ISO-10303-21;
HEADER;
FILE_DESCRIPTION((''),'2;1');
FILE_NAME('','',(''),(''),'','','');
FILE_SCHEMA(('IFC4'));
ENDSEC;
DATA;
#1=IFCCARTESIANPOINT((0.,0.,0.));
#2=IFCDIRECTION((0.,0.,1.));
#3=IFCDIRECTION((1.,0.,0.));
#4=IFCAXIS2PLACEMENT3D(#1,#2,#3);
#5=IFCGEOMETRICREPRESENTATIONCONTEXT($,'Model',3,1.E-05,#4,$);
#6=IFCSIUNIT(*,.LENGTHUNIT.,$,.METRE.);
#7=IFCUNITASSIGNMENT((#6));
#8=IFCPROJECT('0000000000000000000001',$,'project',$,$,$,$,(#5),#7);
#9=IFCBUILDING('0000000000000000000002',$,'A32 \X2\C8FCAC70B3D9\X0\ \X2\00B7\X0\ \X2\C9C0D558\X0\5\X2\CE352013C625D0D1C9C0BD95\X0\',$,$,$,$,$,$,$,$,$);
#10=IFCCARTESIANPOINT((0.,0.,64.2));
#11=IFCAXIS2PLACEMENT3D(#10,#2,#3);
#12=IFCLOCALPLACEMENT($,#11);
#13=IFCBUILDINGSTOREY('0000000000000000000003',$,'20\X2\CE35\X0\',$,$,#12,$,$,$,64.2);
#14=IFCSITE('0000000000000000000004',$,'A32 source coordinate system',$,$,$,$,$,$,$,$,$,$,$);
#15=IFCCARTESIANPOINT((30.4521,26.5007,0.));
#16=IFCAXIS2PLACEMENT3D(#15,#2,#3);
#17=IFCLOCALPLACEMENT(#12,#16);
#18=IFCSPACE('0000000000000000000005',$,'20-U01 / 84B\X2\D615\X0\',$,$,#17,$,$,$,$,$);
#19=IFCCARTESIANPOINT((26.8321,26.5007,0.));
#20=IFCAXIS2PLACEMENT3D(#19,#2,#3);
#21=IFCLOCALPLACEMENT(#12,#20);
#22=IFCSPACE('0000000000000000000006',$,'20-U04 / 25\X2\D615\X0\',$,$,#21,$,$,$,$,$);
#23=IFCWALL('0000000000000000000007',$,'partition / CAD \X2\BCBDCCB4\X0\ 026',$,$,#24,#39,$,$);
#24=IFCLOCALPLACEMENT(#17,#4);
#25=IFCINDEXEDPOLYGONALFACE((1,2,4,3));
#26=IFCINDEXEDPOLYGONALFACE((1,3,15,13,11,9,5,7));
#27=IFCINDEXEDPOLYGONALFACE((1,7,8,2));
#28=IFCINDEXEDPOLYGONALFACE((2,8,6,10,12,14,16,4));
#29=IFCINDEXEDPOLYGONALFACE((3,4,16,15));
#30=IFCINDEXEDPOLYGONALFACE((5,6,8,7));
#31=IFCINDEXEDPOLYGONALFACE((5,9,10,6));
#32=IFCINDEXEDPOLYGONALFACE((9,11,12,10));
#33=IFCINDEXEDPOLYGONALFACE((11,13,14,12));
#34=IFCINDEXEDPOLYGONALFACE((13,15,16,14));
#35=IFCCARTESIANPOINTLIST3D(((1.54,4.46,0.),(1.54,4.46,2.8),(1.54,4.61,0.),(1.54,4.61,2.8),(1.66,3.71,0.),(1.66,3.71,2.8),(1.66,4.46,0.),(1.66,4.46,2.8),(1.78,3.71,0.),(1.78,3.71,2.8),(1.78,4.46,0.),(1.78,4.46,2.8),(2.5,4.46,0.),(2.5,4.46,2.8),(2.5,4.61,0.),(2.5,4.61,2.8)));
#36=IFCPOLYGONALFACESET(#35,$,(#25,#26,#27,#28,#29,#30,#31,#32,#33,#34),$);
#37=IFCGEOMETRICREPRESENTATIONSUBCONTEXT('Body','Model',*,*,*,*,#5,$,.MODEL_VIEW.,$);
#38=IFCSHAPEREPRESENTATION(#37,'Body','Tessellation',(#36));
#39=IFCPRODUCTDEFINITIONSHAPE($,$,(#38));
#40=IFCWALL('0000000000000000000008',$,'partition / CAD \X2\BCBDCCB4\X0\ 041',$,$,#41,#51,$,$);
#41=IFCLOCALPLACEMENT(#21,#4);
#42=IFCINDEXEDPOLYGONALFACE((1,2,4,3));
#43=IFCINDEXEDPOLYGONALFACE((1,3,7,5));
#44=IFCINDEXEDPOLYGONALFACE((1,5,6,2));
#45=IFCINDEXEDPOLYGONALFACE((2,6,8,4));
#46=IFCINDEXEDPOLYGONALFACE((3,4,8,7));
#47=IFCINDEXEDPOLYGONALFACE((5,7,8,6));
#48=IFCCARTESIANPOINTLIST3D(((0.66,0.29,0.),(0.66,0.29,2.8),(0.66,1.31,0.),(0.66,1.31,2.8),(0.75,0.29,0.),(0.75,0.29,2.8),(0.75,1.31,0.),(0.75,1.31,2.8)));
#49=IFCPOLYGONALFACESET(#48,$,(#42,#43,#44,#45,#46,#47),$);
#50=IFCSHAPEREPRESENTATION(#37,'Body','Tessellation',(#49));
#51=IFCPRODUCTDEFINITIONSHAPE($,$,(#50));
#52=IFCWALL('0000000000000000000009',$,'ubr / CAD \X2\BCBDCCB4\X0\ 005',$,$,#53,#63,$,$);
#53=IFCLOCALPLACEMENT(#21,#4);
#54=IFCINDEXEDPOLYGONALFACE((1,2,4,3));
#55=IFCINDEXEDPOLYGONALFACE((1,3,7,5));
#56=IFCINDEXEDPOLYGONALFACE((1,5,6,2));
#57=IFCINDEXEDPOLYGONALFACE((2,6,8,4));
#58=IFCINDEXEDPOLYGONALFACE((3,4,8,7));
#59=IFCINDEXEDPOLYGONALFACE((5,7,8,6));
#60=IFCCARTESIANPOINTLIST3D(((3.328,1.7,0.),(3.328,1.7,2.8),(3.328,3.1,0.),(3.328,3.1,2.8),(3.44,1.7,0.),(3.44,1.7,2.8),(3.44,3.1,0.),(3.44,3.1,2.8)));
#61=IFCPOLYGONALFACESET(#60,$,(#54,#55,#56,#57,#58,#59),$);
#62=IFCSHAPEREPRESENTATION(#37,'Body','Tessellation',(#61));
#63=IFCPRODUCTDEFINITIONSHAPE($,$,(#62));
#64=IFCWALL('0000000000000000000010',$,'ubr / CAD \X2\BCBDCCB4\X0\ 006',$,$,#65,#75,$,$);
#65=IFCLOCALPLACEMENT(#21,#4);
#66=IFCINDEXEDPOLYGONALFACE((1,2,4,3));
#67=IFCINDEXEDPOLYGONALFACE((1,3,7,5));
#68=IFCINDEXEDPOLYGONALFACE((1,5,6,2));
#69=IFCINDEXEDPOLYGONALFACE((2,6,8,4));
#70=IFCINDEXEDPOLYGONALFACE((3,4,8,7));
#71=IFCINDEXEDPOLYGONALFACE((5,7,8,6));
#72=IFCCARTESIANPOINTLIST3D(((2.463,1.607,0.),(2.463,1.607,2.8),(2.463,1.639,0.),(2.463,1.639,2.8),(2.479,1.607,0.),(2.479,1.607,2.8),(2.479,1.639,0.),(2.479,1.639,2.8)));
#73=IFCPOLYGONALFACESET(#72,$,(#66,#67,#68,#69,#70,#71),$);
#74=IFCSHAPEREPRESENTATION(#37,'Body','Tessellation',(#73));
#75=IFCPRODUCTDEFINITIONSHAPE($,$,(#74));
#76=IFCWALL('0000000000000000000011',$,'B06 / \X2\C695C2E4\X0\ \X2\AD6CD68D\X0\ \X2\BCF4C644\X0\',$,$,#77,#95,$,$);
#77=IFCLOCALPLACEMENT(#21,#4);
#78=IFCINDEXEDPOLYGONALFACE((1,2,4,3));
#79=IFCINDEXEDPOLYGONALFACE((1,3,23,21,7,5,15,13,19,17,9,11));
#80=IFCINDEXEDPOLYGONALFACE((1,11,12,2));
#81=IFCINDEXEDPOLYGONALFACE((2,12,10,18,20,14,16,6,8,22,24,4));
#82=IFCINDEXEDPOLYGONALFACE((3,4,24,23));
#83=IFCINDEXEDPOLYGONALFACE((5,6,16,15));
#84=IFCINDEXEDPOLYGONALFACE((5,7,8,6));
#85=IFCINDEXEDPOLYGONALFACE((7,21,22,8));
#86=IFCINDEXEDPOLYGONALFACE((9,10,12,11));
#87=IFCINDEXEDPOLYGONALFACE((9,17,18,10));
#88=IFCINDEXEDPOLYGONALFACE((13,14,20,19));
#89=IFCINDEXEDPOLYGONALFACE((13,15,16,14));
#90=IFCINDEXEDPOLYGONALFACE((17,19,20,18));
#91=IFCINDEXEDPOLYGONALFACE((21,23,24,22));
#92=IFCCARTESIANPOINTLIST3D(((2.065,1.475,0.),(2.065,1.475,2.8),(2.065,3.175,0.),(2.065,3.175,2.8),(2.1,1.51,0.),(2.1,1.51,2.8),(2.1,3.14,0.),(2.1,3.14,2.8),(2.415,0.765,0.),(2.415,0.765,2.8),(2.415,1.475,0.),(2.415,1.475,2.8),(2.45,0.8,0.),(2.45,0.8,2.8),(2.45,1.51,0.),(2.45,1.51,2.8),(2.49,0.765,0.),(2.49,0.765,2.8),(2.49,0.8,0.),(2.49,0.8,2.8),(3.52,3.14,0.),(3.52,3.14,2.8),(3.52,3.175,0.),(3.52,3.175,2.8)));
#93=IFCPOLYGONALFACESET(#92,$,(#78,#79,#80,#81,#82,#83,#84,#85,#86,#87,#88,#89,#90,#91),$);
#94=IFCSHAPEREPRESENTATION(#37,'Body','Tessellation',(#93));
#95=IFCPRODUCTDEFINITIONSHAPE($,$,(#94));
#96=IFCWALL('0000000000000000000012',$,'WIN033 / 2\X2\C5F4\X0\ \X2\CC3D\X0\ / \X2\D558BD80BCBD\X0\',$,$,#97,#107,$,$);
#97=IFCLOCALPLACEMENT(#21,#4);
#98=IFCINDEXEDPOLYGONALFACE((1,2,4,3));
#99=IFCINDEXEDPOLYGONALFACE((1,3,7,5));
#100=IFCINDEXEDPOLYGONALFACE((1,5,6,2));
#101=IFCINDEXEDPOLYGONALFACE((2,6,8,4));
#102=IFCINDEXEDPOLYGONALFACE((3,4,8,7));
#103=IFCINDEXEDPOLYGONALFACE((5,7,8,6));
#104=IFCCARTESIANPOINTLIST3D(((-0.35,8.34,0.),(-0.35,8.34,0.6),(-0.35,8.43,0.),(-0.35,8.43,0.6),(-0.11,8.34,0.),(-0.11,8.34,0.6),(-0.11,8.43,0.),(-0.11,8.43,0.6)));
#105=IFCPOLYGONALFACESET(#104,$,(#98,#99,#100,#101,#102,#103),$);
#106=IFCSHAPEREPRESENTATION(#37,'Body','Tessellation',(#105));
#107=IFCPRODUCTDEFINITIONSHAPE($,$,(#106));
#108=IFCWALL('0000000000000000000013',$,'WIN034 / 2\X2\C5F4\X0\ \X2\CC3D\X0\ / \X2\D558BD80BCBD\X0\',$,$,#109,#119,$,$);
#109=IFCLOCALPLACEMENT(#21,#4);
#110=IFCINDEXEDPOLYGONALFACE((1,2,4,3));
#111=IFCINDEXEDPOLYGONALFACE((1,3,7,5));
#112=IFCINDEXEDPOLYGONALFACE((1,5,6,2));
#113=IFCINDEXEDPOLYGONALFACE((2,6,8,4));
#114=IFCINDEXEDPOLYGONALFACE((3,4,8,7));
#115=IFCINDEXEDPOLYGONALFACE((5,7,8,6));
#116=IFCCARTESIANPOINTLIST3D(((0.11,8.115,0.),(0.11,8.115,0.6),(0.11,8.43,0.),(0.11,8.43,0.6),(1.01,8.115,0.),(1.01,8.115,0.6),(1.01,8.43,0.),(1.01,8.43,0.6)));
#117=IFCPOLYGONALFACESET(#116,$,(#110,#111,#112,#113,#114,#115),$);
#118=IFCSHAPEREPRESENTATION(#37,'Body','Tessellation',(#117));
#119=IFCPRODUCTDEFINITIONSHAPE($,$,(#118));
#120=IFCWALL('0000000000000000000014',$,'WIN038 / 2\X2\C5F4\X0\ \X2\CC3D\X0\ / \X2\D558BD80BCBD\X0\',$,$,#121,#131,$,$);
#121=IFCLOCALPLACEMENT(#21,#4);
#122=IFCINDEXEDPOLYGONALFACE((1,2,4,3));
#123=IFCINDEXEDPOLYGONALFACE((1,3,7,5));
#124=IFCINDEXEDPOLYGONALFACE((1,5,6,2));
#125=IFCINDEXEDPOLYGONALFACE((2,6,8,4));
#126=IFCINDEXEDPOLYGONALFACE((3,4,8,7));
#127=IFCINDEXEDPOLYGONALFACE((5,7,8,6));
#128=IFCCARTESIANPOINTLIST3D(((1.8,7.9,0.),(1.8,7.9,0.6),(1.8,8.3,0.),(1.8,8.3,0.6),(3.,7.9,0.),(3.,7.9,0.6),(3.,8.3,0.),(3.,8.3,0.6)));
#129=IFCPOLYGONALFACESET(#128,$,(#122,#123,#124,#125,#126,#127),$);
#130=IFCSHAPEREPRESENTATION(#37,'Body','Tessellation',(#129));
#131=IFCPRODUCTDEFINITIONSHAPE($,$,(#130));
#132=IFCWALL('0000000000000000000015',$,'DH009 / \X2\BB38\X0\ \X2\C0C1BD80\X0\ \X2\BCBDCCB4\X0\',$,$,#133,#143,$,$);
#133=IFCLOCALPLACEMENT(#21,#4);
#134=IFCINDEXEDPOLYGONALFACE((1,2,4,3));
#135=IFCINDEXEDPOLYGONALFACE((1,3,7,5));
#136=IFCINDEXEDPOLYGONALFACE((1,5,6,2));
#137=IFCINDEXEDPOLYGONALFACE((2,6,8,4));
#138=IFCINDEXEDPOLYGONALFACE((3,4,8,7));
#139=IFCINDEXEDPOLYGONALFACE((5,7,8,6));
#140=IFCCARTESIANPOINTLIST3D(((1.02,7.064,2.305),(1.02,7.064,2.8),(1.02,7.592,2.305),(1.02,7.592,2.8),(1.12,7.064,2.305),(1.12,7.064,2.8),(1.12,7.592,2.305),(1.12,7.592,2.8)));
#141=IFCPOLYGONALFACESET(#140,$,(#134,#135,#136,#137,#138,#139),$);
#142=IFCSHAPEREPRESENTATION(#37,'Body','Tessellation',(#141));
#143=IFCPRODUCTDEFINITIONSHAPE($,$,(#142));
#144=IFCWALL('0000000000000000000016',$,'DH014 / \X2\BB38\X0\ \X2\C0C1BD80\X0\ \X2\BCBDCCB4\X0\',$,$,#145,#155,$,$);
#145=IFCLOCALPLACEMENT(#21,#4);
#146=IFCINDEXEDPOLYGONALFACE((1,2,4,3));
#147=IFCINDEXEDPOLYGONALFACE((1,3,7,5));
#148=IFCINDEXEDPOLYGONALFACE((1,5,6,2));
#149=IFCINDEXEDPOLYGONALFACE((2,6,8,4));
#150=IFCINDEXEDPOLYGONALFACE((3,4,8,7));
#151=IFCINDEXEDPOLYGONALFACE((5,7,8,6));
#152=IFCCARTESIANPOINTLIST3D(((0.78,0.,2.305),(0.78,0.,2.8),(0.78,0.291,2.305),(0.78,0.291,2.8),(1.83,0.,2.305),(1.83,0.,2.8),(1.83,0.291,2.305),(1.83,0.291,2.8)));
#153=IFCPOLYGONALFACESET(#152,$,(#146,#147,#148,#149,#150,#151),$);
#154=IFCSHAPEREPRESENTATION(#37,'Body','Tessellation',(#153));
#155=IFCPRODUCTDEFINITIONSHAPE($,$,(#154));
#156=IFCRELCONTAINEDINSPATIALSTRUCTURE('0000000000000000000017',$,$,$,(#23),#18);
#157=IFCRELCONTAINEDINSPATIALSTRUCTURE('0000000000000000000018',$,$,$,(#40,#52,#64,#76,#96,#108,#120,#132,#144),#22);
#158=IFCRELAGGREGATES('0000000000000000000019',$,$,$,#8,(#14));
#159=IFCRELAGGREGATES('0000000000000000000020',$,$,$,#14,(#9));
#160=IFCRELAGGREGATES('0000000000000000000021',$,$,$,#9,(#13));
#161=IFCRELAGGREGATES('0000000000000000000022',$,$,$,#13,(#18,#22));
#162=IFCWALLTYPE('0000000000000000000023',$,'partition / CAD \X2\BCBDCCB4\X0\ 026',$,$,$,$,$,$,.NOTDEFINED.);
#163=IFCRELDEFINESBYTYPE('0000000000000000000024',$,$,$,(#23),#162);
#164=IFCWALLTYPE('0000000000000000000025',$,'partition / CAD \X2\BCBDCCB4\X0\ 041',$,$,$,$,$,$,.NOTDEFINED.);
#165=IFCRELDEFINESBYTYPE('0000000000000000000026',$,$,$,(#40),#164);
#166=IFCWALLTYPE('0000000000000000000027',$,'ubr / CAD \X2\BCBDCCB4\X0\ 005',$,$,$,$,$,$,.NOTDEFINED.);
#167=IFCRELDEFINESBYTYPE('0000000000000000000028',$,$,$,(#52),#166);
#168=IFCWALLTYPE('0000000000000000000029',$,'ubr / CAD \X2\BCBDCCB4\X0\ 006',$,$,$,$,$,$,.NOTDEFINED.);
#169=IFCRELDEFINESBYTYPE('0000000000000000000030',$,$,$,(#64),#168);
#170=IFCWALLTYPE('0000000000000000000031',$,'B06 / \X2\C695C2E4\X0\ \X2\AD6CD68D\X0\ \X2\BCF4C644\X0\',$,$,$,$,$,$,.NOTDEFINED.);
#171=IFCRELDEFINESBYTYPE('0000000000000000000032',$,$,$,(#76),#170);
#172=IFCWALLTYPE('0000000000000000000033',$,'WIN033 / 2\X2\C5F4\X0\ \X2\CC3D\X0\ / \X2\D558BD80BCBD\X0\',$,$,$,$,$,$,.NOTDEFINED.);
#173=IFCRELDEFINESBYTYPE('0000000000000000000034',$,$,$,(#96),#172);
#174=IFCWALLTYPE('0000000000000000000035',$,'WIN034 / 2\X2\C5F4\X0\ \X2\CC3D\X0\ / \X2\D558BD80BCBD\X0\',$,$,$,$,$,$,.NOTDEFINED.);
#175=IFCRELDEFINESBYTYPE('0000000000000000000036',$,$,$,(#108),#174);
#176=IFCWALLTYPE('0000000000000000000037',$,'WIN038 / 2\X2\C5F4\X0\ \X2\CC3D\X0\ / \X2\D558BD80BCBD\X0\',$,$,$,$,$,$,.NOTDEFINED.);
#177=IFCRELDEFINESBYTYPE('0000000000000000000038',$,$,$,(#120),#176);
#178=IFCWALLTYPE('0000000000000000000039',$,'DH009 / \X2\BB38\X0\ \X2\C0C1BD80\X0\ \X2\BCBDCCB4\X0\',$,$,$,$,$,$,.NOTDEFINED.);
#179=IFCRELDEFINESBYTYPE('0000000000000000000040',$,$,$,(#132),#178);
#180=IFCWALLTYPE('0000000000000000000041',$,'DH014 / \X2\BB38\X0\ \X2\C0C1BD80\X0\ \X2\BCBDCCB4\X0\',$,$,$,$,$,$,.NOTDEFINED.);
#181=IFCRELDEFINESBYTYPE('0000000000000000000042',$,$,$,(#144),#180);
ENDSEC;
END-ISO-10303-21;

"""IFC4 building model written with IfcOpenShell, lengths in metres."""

from ifc_helpers import new_model, si_unit, frame, origin, origin_with_axes, place, context, subcontext, project, spatial, polyline, outline, extrude, source, transform, mapped, type_object, type_shapes, element, save


model = new_model("IFC4")

# Units and contexts
model_context = context("Model", 3, precision=1e-05, world=origin_with_axes())
body_context = subcontext(model_context, "Body", "Model", "MODEL_VIEW")
ifc_project = project(units=[si_unit("LENGTHUNIT", "METRE")], contexts=[model_context])

# Site, building, storey, space
site = spatial("IfcSite", under=ifc_project, Name="A32 source coordinate system")
building = spatial("IfcBuilding", under=site, Name="A32 주거동 · 지하5층–옥탑지붕")
storey_placement = place(None, frame((0.0, 0.0, 64.2), z_axis=(0.0, 0.0, 1.0), x_axis=(1.0, 0.0, 0.0)))
storey = spatial("IfcBuildingStorey", under=building, at=storey_placement, Name="20층", Elevation=64.2)
space_1_placement = place(storey_placement, frame((30.4521, 26.5007, 0.0), z_axis=(0.0, 0.0, 1.0), x_axis=(1.0, 0.0, 0.0)))
space_1 = spatial("IfcSpace", under=storey, at=space_1_placement, Name="20-U01 / 84B형")

# Wall
wall_type_1 = type_object("IfcWallType", Name="partition / CAD 벽체 026", PredefinedType="NOTDEFINED")
shared_shape_1 = source(origin(), body_context, "Body", "SweptSolid", [
    extrude(outline(polyline([(1.54, 4.46), (1.54, 4.61), (2.5, 4.61), (2.5, 4.46), (1.78, 4.46), (1.78, 3.71), (1.66, 3.71), (1.66, 4.46), (1.54, 4.46)])), origin(), (0.0, 0.0, 1.0), 2.8),
])
type_shapes(wall_type_1, [shared_shape_1])
wall_1_placement = place(space_1_placement, origin_with_axes())
element("IfcWall", 1, at=wall_1_placement, inside=space_1, type_object=wall_type_1, Name="partition / CAD 벽체 026", context=body_context, shape_type="MappedRepresentation", body=[
    mapped(shared_shape_1, transform((0.0, 0.0, 0.0), scale=1.0)),
])

# Shared definitions
space_2_placement = place(storey_placement, frame((26.8321, 26.5007, 0.0), z_axis=(0.0, 0.0, 1.0), x_axis=(1.0, 0.0, 0.0)))
space_2 = spatial("IfcSpace", under=storey, at=space_2_placement, Name="20-U04 / 25형")

# Walls
wall_type_2 = type_object("IfcWallType", Name="partition / CAD 벽체 041", PredefinedType="NOTDEFINED")
shared_shape_2 = source(origin(), body_context, "Body", "SweptSolid", [
    extrude(outline(polyline([(0.75, 1.31), (0.75, 0.29), (0.66, 0.29), (0.66, 1.31), (0.75, 1.31)])), origin(), (0.0, 0.0, 1.0), 2.8),
])
type_shapes(wall_type_2, [shared_shape_2])
wall_2_placement = place(space_2_placement, origin_with_axes())
element("IfcWall", 2, at=wall_2_placement, inside=space_2, type_object=wall_type_2, Name="partition / CAD 벽체 041", context=body_context, shape_type="MappedRepresentation", body=[
    mapped(shared_shape_2, transform((0.0, 0.0, 0.0), scale=1.0)),
])
wall_type_3 = type_object("IfcWallType", Name="ubr / CAD 벽체 005", PredefinedType="NOTDEFINED")
shared_shape_3 = source(origin(), body_context, "Body", "SweptSolid", [
    extrude(outline(polyline([(3.44, 3.1), (3.44, 1.7), (3.328, 1.7), (3.328, 3.1), (3.44, 3.1)])), origin(), (0.0, 0.0, 1.0), 2.8),
])
type_shapes(wall_type_3, [shared_shape_3])
wall_3_placement = place(space_2_placement, origin_with_axes())
element("IfcWall", 3, at=wall_3_placement, inside=space_2, type_object=wall_type_3, Name="ubr / CAD 벽체 005", context=body_context, shape_type="MappedRepresentation", body=[
    mapped(shared_shape_3, transform((0.0, 0.0, 0.0), scale=1.0)),
])
wall_type_4 = type_object("IfcWallType", Name="ubr / CAD 벽체 006", PredefinedType="NOTDEFINED")
shared_shape_4 = source(origin(), body_context, "Body", "SweptSolid", [
    extrude(outline(polyline([(2.463, 1.639), (2.479, 1.639), (2.479, 1.607), (2.463, 1.607), (2.463, 1.639)])), origin(), (0.0, 0.0, 1.0), 2.8),
])
type_shapes(wall_type_4, [shared_shape_4])
wall_4_placement = place(space_2_placement, origin_with_axes())
element("IfcWall", 4, at=wall_4_placement, inside=space_2, type_object=wall_type_4, Name="ubr / CAD 벽체 006", context=body_context, shape_type="MappedRepresentation", body=[
    mapped(shared_shape_4, transform((0.0, 0.0, 0.0), scale=1.0)),
])
wall_type_5 = type_object("IfcWallType", Name="B06 / 욕실 구획 보완", PredefinedType="NOTDEFINED")
shared_shape_5 = source(origin(), body_context, "Body", "SweptSolid", [
    extrude(outline(polyline([(3.52, 3.14), (2.1, 3.14), (2.1, 1.51), (2.45, 1.51), (2.45, 0.8), (2.49, 0.8), (2.49, 0.765), (2.415, 0.765), (2.415, 1.475), (2.065, 1.475), (2.065, 3.175), (3.52, 3.175), (3.52, 3.14)])), origin(), (0.0, 0.0, 1.0), 2.8),
])
type_shapes(wall_type_5, [shared_shape_5])
wall_5_placement = place(space_2_placement, origin_with_axes())
element("IfcWall", 5, at=wall_5_placement, inside=space_2, type_object=wall_type_5, Name="B06 / 욕실 구획 보완", context=body_context, shape_type="MappedRepresentation", body=[
    mapped(shared_shape_5, transform((0.0, 0.0, 0.0), scale=1.0)),
])
wall_type_6 = type_object("IfcWallType", Name="WIN033 / 2열 창 / 하부벽", PredefinedType="NOTDEFINED")
shared_shape_6 = source(origin(), body_context, "Body", "SweptSolid", [
    extrude(outline(polyline([(-0.11, 8.43), (-0.11, 8.34), (-0.35, 8.34), (-0.35, 8.43), (-0.11, 8.43)])), origin(), (0.0, 0.0, 1.0), 0.6),
])
type_shapes(wall_type_6, [shared_shape_6])
wall_6_placement = place(space_2_placement, origin_with_axes())
element("IfcWall", 6, at=wall_6_placement, inside=space_2, type_object=wall_type_6, Name="WIN033 / 2열 창 / 하부벽", context=body_context, shape_type="MappedRepresentation", body=[
    mapped(shared_shape_6, transform((0.0, 0.0, 0.0), scale=1.0)),
])
wall_type_7 = type_object("IfcWallType", Name="WIN034 / 2열 창 / 하부벽", PredefinedType="NOTDEFINED")
shared_shape_7 = source(origin(), body_context, "Body", "SweptSolid", [
    extrude(outline(polyline([(0.11, 8.115), (0.11, 8.43), (1.01, 8.43), (1.01, 8.115), (0.11, 8.115)])), origin(), (0.0, 0.0, 1.0), 0.6),
])
type_shapes(wall_type_7, [shared_shape_7])
wall_7_placement = place(space_2_placement, origin_with_axes())
element("IfcWall", 7, at=wall_7_placement, inside=space_2, type_object=wall_type_7, Name="WIN034 / 2열 창 / 하부벽", context=body_context, shape_type="MappedRepresentation", body=[
    mapped(shared_shape_7, transform((0.0, 0.0, 0.0), scale=1.0)),
])
wall_type_8 = type_object("IfcWallType", Name="WIN038 / 2열 창 / 하부벽", PredefinedType="NOTDEFINED")
shared_shape_8 = source(origin(), body_context, "Body", "SweptSolid", [
    extrude(outline(polyline([(1.8, 7.9), (1.8, 8.3), (3.0, 8.3), (3.0, 7.9), (1.8, 7.9)])), origin(), (0.0, 0.0, 1.0), 0.6),
])
type_shapes(wall_type_8, [shared_shape_8])
wall_8_placement = place(space_2_placement, origin_with_axes())
element("IfcWall", 8, at=wall_8_placement, inside=space_2, type_object=wall_type_8, Name="WIN038 / 2열 창 / 하부벽", context=body_context, shape_type="MappedRepresentation", body=[
    mapped(shared_shape_8, transform((0.0, 0.0, 0.0), scale=1.0)),
])
wall_type_9 = type_object("IfcWallType", Name="DH009 / 문 상부 벽체", PredefinedType="NOTDEFINED")
shared_shape_9 = source(origin(), body_context, "Body", "SweptSolid", [
    extrude(outline(polyline([(1.02, 7.064), (1.02, 7.592), (1.12, 7.592), (1.12, 7.064), (1.02, 7.064)])), frame((0.0, 0.0, 2.305)), (0.0, 0.0, 1.0), 0.495),
])
type_shapes(wall_type_9, [shared_shape_9])
wall_9_placement = place(space_2_placement, origin_with_axes())
element("IfcWall", 9, at=wall_9_placement, inside=space_2, type_object=wall_type_9, Name="DH009 / 문 상부 벽체", context=body_context, shape_type="MappedRepresentation", body=[
    mapped(shared_shape_9, transform((0.0, 0.0, 0.0), scale=1.0)),
])
wall_type_10 = type_object("IfcWallType", Name="DH014 / 문 상부 벽체", PredefinedType="NOTDEFINED")
shared_shape_10 = source(origin(), body_context, "Body", "SweptSolid", [
    extrude(outline(polyline([(0.78, 0.291), (1.83, 0.291), (1.83, 0.0), (0.78, 0.0), (0.78, 0.291)])), frame((0.0, 0.0, 2.305)), (0.0, 0.0, 1.0), 0.495),
])
type_shapes(wall_type_10, [shared_shape_10])
wall_10_placement = place(space_2_placement, origin_with_axes())
element("IfcWall", 10, at=wall_10_placement, inside=space_2, type_object=wall_type_10, Name="DH014 / 문 상부 벽체", context=body_context, shape_type="MappedRepresentation", body=[
    mapped(shared_shape_10, transform((0.0, 0.0, 0.0), scale=1.0)),
])

save(model, "model.ifc")
